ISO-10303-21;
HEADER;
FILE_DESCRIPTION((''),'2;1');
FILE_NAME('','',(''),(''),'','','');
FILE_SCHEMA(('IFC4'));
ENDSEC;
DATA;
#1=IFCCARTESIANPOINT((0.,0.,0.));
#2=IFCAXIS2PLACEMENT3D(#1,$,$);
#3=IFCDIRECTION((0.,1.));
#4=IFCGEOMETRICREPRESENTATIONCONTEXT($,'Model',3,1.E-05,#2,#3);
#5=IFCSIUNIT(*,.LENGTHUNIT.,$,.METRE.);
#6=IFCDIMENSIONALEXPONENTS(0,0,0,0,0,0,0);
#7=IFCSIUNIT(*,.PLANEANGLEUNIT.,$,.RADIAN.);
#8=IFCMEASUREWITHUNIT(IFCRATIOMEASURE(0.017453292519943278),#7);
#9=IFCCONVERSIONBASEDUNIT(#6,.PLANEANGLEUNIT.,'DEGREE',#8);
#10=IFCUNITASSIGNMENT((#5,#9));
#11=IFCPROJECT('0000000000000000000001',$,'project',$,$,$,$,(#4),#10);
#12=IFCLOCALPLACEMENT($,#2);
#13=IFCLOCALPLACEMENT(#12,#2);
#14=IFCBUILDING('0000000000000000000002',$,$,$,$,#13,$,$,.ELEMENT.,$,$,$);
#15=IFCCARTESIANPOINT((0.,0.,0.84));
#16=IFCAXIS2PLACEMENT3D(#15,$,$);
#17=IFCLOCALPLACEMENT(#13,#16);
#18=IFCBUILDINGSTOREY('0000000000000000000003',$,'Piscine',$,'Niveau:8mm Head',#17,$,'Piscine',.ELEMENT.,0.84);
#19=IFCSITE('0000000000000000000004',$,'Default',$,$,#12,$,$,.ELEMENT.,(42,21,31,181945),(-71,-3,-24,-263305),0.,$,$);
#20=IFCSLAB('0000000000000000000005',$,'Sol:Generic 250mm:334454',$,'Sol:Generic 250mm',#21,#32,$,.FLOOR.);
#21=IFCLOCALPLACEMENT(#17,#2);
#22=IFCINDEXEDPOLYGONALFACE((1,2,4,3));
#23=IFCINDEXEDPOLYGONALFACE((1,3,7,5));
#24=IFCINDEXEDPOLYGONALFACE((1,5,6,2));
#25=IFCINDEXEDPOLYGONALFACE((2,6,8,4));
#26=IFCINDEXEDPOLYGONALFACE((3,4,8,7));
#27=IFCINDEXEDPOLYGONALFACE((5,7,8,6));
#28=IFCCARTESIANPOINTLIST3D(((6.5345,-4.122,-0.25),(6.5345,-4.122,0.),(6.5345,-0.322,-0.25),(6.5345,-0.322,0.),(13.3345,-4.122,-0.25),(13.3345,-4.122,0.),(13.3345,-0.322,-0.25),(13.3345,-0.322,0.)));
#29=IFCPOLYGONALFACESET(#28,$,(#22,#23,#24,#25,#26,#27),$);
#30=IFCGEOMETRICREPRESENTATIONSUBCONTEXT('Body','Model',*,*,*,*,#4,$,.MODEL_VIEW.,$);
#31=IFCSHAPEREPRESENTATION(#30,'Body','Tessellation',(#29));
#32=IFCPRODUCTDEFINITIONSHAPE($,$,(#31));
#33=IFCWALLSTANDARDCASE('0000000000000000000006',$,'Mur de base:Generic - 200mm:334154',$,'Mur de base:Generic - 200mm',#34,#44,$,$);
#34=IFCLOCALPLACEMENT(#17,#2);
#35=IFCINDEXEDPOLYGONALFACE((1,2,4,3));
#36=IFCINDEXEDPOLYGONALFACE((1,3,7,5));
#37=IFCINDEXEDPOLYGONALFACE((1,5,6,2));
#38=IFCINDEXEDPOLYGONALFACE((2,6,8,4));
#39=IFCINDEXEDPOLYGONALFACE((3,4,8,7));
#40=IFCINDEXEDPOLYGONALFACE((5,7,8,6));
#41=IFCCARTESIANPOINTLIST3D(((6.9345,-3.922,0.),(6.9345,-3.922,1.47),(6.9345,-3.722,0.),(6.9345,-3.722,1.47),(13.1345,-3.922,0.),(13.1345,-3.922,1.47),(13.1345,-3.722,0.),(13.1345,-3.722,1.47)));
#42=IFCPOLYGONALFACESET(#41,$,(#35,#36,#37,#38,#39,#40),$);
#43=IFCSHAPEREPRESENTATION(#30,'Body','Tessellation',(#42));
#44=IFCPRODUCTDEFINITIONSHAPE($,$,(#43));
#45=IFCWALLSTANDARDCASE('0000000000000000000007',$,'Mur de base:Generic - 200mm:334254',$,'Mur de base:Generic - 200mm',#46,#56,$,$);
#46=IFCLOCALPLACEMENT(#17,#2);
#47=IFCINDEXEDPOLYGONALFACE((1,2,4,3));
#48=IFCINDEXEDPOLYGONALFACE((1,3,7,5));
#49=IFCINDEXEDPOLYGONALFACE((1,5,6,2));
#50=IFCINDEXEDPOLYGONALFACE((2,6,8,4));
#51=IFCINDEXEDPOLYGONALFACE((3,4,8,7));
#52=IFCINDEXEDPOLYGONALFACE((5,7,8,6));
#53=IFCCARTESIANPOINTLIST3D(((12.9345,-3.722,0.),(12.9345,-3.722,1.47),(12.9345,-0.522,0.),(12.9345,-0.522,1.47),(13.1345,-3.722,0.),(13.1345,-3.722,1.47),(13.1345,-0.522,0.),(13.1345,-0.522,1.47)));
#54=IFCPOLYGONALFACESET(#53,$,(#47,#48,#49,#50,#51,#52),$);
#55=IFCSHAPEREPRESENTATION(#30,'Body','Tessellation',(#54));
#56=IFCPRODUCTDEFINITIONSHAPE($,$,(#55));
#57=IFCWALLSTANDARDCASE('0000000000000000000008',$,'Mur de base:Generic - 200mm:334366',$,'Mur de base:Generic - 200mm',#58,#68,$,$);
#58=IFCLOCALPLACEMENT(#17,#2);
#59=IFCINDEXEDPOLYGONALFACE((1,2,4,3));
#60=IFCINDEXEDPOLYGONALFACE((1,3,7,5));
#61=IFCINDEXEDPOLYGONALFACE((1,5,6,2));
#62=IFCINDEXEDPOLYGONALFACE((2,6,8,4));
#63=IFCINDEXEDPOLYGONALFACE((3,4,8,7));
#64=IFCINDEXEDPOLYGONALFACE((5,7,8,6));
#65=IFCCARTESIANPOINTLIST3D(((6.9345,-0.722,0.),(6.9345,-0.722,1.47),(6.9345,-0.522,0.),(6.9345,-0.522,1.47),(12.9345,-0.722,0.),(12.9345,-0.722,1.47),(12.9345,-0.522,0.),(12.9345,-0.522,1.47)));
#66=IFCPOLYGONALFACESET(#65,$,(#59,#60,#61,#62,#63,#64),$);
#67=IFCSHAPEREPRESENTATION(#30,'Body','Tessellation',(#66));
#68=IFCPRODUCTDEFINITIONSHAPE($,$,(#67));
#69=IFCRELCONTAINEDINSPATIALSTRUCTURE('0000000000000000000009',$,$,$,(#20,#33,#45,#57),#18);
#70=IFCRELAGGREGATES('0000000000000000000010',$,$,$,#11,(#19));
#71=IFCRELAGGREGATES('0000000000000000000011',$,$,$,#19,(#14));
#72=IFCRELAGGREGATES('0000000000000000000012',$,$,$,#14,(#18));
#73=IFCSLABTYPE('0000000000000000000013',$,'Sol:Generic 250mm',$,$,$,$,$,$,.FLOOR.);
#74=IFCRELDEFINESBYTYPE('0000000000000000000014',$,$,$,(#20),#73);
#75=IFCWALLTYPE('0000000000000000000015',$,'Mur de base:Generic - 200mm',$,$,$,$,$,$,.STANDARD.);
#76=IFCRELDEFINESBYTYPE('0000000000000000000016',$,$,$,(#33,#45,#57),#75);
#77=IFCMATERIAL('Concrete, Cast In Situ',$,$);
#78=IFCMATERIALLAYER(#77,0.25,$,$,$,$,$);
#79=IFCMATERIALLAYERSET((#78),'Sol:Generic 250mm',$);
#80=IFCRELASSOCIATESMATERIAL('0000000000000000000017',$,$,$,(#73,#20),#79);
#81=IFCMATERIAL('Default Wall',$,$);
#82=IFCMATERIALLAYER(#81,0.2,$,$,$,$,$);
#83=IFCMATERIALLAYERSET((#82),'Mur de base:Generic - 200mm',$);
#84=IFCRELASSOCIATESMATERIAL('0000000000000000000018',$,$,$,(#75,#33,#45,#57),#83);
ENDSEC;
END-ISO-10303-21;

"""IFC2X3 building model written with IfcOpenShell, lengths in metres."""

from ifc_helpers import new_model, entity, si_unit, converted_unit, direction, frame, frame_2d, origin, place, context, subcontext, project, spatial, rectangle, extrude, material, layer, layer_set, layer_usage, type_object, element, save


model = new_model("IFC2X3")

# Units and contexts
model_context = context("Model", 3, precision=1e-05, world=origin(), true_north=direction((0.0, 1.0)))
body_context = subcontext(model_context, "Body", "Model", "MODEL_VIEW")
ifc_project = project(units=[si_unit("LENGTHUNIT", "METRE"), converted_unit("PLANEANGLEUNIT", "DEGREE", entity("IfcRatioMeasure", 0.017453292519943278), si_unit("PLANEANGLEUNIT", "RADIAN"), dimensions=[0, 0, 0, 0, 0, 0, 0])], contexts=[model_context])

# Site, building, storey
site_placement = place(None, origin())
site = spatial("IfcSite", under=ifc_project, at=site_placement, Name="Default", CompositionType="ELEMENT", RefLatitude=(42, 21, 31, 181945), RefLongitude=(-71, -3, -24, -263305), RefElevation=0.0)
building_placement = place(site_placement, origin())
building = spatial("IfcBuilding", under=site, at=building_placement, CompositionType="ELEMENT")
storey_placement = place(building_placement, frame((0.0, 0.0, 0.84)))
storey = spatial("IfcBuildingStorey", under=building, at=storey_placement, Name="Piscine", ObjectType="Niveau:8mm Head", LongName="Piscine", CompositionType="ELEMENT", Elevation=0.84)

# Slab
ifc_material_1 = material(Name="Concrete, Cast In Situ")
ifc_layer_1 = layer(ifc_material_1, 0.25)
ifc_layer_set_1 = layer_set([ifc_layer_1], Name="Sol:Generic 250mm")
ifc_layer_usage_1 = layer_usage(ifc_layer_set_1, "AXIS3", "POSITIVE", 0.0)
slab_type = type_object("IfcSlabType", Name="Sol:Generic 250mm", PredefinedType="FLOOR", material=ifc_layer_set_1)
slab_placement = place(storey_placement, origin())
element("IfcSlab", 1, at=slab_placement, inside=storey, type_object=slab_type, material=ifc_layer_usage_1, Name="Sol:Generic 250mm:334454", ObjectType="Sol:Generic 250mm", PredefinedType="FLOOR", context=body_context, shape_type="SweptSolid", body=[
    extrude(rectangle(XDim=3.8, YDim=6.8, at=frame_2d((0.0, 0.0), x_axis=(1.0, 0.0))), frame((9.9345, -2.222, 0.0), z_axis=(0.0, 0.0, -1.0), x_axis=(0.0, 1.0, 0.0)), (0.0, 0.0, 1.0), 0.25),
])

# Walls
ifc_material_2 = material(Name="Default Wall")
ifc_layer_2 = layer(ifc_material_2, 0.2)
ifc_layer_set_2 = layer_set([ifc_layer_2], Name="Mur de base:Generic - 200mm")
ifc_layer_usage_2 = layer_usage(ifc_layer_set_2, "AXIS2", "NEGATIVE", 0.1)
wall_type = type_object("IfcWallType", Name="Mur de base:Generic - 200mm", PredefinedType="STANDARD", material=ifc_layer_set_2)
wall_1_placement = place(storey_placement, frame((6.9345, -3.822, 0.0)))
element("IfcWallStandardCase", 2, at=wall_1_placement, inside=storey, type_object=wall_type, material=ifc_layer_usage_2, Name="Mur de base:Generic - 200mm:334154", ObjectType="Mur de base:Generic - 200mm", context=body_context, shape_type="SweptSolid", body=[
    extrude(rectangle(XDim=6.2, YDim=0.2, at=frame_2d((3.1, 0.0), x_axis=(-1.0, 0.0))), origin(), (0.0, 0.0, 1.0), 1.47),
])
wall_2_placement = place(storey_placement, frame((13.0345, -3.722, 0.0), z_axis=(0.0, 0.0, 1.0), x_axis=(0.0, 1.0, 0.0)))
element("IfcWallStandardCase", 3, at=wall_2_placement, inside=storey, type_object=wall_type, material=ifc_layer_usage_2, Name="Mur de base:Generic - 200mm:334254", ObjectType="Mur de base:Generic - 200mm", context=body_context, shape_type="SweptSolid", body=[
    extrude(rectangle(XDim=3.2, YDim=0.2, at=frame_2d((1.6, 0.0), x_axis=(-1.0, 0.0))), origin(), (0.0, 0.0, 1.0), 1.47),
])
wall_3_placement = place(storey_placement, frame((12.9345, -0.622, 0.0), z_axis=(0.0, 0.0, 1.0), x_axis=(-1.0, 0.0, 0.0)))
element("IfcWallStandardCase", 4, at=wall_3_placement, inside=storey, type_object=wall_type, material=ifc_layer_usage_2, Name="Mur de base:Generic - 200mm:334366", ObjectType="Mur de base:Generic - 200mm", context=body_context, shape_type="SweptSolid", body=[
    extrude(rectangle(XDim=6.0, YDim=0.2, at=frame_2d((3.0, 0.0), x_axis=(-1.0, 0.0))), origin(), (0.0, 0.0, 1.0), 1.47),
])

save(model, "model.ifc")
